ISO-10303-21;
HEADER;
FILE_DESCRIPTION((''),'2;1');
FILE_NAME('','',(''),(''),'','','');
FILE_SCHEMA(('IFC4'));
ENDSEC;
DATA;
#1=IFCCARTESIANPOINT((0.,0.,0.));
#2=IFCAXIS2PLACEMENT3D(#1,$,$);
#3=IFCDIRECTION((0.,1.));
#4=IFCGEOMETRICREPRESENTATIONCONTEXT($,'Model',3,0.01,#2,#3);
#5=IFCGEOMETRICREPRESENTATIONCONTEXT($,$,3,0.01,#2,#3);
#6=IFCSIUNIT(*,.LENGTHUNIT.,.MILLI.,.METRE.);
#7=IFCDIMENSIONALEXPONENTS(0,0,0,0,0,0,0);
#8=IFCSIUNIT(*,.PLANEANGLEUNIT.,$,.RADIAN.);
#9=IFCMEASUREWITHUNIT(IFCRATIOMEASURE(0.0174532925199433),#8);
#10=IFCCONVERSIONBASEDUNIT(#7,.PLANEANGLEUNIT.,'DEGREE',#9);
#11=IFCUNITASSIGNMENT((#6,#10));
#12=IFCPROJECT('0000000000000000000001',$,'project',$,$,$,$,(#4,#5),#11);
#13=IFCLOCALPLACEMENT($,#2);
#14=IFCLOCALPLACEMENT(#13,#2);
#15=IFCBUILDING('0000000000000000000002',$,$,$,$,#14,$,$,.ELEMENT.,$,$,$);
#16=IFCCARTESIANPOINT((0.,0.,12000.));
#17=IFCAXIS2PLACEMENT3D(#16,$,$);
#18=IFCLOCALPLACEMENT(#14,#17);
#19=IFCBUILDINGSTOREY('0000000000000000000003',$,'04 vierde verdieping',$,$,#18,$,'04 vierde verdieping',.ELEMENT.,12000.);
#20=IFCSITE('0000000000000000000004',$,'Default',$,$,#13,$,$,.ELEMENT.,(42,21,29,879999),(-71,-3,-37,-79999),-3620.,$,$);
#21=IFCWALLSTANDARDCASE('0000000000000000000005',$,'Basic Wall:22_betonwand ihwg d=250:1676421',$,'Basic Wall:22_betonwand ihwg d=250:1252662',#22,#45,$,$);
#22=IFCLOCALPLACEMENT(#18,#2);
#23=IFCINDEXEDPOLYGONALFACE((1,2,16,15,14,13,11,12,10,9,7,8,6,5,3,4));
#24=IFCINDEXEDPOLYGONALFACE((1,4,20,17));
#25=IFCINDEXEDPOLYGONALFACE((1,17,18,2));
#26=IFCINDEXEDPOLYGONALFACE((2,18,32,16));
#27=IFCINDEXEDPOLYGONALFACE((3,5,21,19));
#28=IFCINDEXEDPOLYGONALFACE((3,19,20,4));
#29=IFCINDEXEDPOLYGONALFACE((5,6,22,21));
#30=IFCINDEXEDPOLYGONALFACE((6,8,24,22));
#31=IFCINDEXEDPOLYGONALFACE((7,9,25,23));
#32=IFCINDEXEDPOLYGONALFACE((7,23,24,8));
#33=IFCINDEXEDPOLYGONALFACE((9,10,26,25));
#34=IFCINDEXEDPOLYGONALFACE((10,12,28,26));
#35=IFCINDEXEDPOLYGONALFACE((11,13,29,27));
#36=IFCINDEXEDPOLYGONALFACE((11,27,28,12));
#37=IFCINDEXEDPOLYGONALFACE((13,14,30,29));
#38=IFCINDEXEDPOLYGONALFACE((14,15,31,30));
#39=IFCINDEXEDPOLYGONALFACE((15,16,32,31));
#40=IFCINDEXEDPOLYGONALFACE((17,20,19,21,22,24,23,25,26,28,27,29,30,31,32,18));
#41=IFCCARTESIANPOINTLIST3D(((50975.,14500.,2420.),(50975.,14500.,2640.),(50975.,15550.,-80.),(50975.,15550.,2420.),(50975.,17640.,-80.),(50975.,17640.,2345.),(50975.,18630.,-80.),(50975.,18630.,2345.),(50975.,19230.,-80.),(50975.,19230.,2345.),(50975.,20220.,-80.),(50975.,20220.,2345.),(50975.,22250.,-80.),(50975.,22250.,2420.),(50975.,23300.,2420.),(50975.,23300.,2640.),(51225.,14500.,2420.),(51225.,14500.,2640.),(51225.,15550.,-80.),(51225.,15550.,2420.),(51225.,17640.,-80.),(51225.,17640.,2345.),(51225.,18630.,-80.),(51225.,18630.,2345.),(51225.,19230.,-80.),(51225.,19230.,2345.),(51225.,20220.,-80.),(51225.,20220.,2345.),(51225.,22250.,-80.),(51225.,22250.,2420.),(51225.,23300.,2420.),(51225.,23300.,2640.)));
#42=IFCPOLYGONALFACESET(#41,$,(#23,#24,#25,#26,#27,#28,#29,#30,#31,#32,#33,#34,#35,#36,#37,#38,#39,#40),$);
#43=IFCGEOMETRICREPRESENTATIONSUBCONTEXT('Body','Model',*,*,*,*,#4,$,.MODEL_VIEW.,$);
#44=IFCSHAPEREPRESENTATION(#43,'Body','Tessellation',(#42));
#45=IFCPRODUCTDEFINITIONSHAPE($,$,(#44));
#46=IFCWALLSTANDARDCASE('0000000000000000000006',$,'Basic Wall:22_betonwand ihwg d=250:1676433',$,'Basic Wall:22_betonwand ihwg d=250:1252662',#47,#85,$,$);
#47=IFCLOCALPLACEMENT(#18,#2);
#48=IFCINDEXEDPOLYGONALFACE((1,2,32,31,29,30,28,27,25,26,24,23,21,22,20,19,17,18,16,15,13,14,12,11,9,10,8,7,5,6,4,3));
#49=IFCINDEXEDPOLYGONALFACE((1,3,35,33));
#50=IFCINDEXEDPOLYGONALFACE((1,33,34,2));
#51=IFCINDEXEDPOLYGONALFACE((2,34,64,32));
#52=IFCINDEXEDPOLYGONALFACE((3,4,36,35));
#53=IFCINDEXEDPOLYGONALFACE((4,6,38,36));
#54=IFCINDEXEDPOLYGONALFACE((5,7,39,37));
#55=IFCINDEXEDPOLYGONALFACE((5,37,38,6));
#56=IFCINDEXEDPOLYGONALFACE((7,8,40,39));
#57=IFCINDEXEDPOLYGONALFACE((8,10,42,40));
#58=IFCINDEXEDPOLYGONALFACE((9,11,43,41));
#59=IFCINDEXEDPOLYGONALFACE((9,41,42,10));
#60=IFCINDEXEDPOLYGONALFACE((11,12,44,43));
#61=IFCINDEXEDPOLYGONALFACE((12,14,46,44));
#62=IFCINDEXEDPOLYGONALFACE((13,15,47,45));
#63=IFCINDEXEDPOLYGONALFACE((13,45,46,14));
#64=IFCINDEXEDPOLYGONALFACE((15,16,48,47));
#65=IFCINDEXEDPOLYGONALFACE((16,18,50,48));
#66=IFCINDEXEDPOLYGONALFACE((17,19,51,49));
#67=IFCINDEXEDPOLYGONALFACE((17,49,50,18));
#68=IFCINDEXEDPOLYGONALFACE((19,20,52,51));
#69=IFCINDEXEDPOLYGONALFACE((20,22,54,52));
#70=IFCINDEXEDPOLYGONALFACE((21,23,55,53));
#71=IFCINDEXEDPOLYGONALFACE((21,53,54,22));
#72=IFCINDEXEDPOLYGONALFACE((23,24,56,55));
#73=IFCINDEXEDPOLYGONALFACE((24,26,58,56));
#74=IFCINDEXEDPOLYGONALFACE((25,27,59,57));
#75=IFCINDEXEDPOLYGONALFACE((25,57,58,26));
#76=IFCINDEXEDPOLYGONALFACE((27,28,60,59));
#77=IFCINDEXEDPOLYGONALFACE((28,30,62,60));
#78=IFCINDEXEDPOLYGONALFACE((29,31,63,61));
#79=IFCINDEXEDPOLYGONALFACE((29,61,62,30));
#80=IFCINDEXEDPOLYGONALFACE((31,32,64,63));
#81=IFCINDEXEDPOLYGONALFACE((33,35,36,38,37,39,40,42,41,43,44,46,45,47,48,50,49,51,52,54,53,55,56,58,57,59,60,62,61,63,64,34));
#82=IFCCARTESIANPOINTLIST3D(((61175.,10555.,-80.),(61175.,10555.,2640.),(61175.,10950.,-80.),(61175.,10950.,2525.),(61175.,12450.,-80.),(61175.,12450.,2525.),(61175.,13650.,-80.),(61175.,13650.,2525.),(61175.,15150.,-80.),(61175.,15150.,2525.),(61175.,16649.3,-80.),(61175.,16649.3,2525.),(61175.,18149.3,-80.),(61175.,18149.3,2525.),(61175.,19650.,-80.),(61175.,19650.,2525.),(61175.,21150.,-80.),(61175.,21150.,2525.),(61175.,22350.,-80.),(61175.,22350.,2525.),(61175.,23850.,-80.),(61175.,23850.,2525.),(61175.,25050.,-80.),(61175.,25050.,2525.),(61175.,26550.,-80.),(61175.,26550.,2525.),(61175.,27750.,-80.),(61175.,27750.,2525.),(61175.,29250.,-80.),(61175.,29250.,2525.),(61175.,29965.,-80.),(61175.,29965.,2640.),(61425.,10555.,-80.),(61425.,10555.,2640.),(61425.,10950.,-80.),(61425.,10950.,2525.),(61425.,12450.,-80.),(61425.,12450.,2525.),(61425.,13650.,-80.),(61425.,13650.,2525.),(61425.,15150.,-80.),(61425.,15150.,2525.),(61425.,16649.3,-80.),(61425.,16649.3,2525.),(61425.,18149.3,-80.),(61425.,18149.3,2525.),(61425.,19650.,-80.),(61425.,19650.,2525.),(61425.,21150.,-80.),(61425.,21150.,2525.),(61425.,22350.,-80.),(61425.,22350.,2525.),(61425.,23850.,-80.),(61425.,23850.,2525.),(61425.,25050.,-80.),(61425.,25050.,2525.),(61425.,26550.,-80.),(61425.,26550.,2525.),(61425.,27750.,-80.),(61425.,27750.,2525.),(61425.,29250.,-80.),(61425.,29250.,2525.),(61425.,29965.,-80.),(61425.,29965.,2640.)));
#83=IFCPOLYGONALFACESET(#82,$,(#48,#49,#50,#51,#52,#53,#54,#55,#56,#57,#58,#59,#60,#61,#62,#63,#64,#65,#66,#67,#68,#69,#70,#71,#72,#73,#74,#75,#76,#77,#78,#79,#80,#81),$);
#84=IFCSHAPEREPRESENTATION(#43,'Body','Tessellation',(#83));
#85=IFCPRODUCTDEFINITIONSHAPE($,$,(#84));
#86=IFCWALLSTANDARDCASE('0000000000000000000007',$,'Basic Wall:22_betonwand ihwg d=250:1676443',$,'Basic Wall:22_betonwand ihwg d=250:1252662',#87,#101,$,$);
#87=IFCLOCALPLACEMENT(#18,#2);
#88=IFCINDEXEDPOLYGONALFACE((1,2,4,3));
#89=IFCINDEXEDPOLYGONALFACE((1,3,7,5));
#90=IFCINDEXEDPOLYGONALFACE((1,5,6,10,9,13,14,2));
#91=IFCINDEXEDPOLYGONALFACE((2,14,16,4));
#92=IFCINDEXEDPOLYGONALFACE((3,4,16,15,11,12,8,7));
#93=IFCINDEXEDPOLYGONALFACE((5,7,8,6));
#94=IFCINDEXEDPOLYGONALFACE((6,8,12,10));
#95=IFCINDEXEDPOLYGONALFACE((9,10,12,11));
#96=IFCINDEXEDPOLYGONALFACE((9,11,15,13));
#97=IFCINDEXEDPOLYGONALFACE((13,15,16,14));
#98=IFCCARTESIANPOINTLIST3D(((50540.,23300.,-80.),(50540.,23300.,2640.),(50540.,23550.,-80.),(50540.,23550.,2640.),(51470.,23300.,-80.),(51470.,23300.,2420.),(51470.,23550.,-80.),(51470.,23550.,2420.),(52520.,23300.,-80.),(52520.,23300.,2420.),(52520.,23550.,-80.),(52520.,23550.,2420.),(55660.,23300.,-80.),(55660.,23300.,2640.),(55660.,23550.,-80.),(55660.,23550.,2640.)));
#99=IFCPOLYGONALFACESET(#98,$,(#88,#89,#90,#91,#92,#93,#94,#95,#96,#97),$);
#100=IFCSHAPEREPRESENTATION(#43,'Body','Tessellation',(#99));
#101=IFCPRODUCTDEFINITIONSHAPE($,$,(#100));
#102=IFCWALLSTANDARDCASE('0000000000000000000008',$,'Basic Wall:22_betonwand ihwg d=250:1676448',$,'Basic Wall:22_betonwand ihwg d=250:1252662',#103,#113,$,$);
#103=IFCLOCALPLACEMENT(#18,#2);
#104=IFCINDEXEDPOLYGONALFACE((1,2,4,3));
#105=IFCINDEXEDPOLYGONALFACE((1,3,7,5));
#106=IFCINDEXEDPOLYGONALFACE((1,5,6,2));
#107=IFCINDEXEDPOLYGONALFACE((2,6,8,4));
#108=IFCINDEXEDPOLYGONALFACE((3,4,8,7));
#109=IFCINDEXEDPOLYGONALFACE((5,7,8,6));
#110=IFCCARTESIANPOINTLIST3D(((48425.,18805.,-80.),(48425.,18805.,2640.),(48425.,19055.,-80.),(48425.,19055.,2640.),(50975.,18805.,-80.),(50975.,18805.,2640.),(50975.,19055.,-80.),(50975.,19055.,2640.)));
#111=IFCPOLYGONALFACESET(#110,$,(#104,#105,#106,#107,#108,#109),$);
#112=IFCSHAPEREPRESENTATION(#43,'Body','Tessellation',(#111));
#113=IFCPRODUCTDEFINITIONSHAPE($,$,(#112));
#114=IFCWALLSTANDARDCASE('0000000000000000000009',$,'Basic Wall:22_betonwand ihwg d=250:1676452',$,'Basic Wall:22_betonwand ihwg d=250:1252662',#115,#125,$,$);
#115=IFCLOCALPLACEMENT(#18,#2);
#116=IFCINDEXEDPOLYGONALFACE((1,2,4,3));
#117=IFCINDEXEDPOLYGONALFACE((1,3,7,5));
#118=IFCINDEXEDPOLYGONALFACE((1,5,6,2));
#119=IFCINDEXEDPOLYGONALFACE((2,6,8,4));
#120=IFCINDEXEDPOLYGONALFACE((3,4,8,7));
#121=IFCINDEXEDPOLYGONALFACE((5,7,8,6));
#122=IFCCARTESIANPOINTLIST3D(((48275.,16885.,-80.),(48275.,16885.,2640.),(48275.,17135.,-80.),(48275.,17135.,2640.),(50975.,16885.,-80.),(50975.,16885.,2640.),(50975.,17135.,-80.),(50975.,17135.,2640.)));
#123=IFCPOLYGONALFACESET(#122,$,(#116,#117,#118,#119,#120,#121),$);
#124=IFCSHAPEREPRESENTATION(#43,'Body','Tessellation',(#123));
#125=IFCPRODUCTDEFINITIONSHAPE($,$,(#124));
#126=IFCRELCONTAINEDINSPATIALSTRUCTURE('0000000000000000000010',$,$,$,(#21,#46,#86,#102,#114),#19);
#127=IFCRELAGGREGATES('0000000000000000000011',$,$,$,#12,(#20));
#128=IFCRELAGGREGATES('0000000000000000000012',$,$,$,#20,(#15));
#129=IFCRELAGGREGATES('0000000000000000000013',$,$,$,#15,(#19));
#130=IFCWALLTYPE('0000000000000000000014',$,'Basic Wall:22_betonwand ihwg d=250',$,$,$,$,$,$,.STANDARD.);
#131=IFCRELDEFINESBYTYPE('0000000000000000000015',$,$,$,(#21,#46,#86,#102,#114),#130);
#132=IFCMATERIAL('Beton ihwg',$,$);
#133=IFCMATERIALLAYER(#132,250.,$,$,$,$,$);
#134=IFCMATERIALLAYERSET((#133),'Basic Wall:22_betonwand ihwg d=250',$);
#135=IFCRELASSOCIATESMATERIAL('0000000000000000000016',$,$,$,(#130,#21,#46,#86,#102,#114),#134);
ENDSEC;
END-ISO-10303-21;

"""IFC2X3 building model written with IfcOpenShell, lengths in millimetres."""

from ifc_helpers import new_model, entity, si_unit, converted_unit, direction, frame, frame_2d, origin, origin_2d_with_axis, place, context, subcontext, project, spatial, rectangle, extrude, material, layer, layer_set, layer_usage, type_object, element, save


model = new_model("IFC2X3")

# Units and contexts
model_context = context("Model", 3, precision=0.01, world=origin(), true_north=direction((0.0, 1.0)))
context_of_model = context(None, 3, precision=0.01, world=origin(), true_north=direction((0.0, 1.0)))
body_context = subcontext(model_context, "Body", "Model", "MODEL_VIEW")
ifc_project = project(units=[si_unit("LENGTHUNIT", "METRE", prefix="MILLI"), converted_unit("PLANEANGLEUNIT", "DEGREE", entity("IfcRatioMeasure", 0.0174532925199433), si_unit("PLANEANGLEUNIT", "RADIAN"), dimensions=[0, 0, 0, 0, 0, 0, 0])], contexts=[model_context, context_of_model])

# Site, building, storey
site_placement = place(None, origin())
site = spatial("IfcSite", under=ifc_project, at=site_placement, Name="Default", CompositionType="ELEMENT", RefLatitude=(42, 21, 29, 879999), RefLongitude=(-71, -3, -37, -79999), RefElevation=-3620.0)
building_placement = place(site_placement, origin())
building = spatial("IfcBuilding", under=site, at=building_placement, CompositionType="ELEMENT")
storey_placement = place(building_placement, frame((0.0, 0.0, 12000.0)))
storey = spatial("IfcBuildingStorey", under=building, at=storey_placement, Name="04 vierde verdieping", LongName="04 vierde verdieping", CompositionType="ELEMENT", Elevation=12000.0)

# Walls, openings
ifc_material_1 = material(Name="Beton ihwg")
ifc_layer_1 = layer(ifc_material_1, 250.0)
ifc_layer_set_1 = layer_set([ifc_layer_1], Name="Basic Wall:22_betonwand ihwg d=250")
ifc_layer_usage_1 = layer_usage(ifc_layer_set_1, "AXIS2", "NEGATIVE", 125.0)
wall_type_1 = type_object("IfcWallType", Name="Basic Wall:22_betonwand ihwg d=250", PredefinedType="STANDARD", material=ifc_layer_set_1)
wall_1_placement = place(storey_placement, frame((51100.0, 23300.0, -80.0), z_axis=(0.0, 0.0, 1.0), x_axis=(0.0, -1.0, 0.0)))
wall_1 = element("IfcWallStandardCase", 1, at=wall_1_placement, inside=storey, type_object=wall_type_1, material=ifc_layer_usage_1, Name="Basic Wall:22_betonwand ihwg d=250:1676421", ObjectType="Basic Wall:22_betonwand ihwg d=250:1252662", context=body_context, shape_type="SweptSolid", body=[
    extrude(rectangle(XDim=8800.0, YDim=250.0, at=frame_2d((4400.0, 0.0), x_axis=(-1.0, 0.0))), origin(), (0.0, 0.0, 1.0), 2720.0),
])
opening_1_placement = place(wall_1_placement, frame((23300.0, -51100.0, 80.0), z_axis=(0.0, 0.0, 1.0), x_axis=(0.0, 1.0, 0.0)))
element("IfcOpeningElement", 2, at=opening_1_placement, cuts=wall_1, ObjectType="Opening", context=body_context, shape_type="SweptSolid", body=[
    extrude(rectangle(XDim=2500.0, YDim=1050.0, at=frame_2d((0.0, 0.0), x_axis=(0.0, 1.0))), frame((50700.0, 15025.0, 1170.0), z_axis=(1.0, 0.0, 0.0), x_axis=(0.0, -1.0, 0.0)), (0.0, 0.0, 1.0), 800.0),
])
opening_2_placement = place(wall_1_placement, frame((23300.0, -51100.0, 80.0), z_axis=(0.0, 0.0, 1.0), x_axis=(0.0, 1.0, 0.0)))
element("IfcOpeningElement", 3, at=opening_2_placement, cuts=wall_1, ObjectType="Opening", context=body_context, shape_type="SweptSolid", body=[
    extrude(rectangle(XDim=2425.0, YDim=990.0, at=frame_2d((0.0, 0.0), x_axis=(1.0, 0.0))), frame((50700.0, 19725.0, 1132.5), z_axis=(1.0, 0.0, 0.0), x_axis=(0.0, 0.0, -1.0)), (0.0, 0.0, 1.0), 800.0),
])
opening_3_placement = place(wall_1_placement, frame((23300.0, -51100.0, 80.0), z_axis=(0.0, 0.0, 1.0), x_axis=(0.0, 1.0, 0.0)))
element("IfcOpeningElement", 4, at=opening_3_placement, cuts=wall_1, ObjectType="Opening", context=body_context, shape_type="SweptSolid", body=[
    extrude(rectangle(XDim=2425.0, YDim=990.0, at=origin_2d_with_axis()), frame((50700.0, 18135.0, 1132.5), z_axis=(1.0, 0.0, 0.0), x_axis=(0.0, 0.0, -1.0)), (0.0, 0.0, 1.0), 800.0),
])
opening_4_placement = place(wall_1_placement, frame((23300.0, -51100.0, 80.0), z_axis=(0.0, 0.0, 1.0), x_axis=(0.0, 1.0, 0.0)))
element("IfcOpeningElement", 5, at=opening_4_placement, cuts=wall_1, ObjectType="Opening", context=body_context, shape_type="SweptSolid", body=[
    extrude(rectangle(XDim=2500.0, YDim=1050.0, at=frame_2d((0.0, 0.0), x_axis=(1.0, 0.0))), frame((50700.0, 22775.0, 1170.0), z_axis=(1.0, 0.0, 0.0), x_axis=(0.0, 0.0, -1.0)), (0.0, 0.0, 1.0), 800.0),
])
ifc_layer_usage_2 = layer_usage(ifc_layer_set_1, "AXIS2", "POSITIVE", -125.0)
wall_2_placement = place(storey_placement, frame((61300.0, 29965.0, -80.0), z_axis=(0.0, 0.0, 1.0), x_axis=(0.0, -1.0, 0.0)))
wall_2 = element("IfcWallStandardCase", 6, at=wall_2_placement, inside=storey, type_object=wall_type_1, material=ifc_layer_usage_2, Name="Basic Wall:22_betonwand ihwg d=250:1676433", ObjectType="Basic Wall:22_betonwand ihwg d=250:1252662", context=body_context, shape_type="SweptSolid", body=[
    extrude(rectangle(XDim=19410.0, YDim=250.0, at=frame_2d((9705.0, 0.0), x_axis=(-1.0, 0.0))), origin(), (0.0, 0.0, 1.0), 2720.0),
])
opening_5_placement = place(wall_2_placement, frame((29965.0, -61300.0, 80.0), z_axis=(0.0, 0.0, 1.0), x_axis=(0.0, 1.0, 0.0)))
element("IfcOpeningElement", 7, at=opening_5_placement, cuts=wall_2, ObjectType="Opening", context=body_context, shape_type="SweptSolid", body=[
    extrude(rectangle(XDim=2605.0, YDim=1500.0, at=frame_2d((0.0, 0.0), x_axis=(1.0, 0.0))), frame((59901.0, 28500.0, 1222.5), z_axis=(1.0, 0.0, 0.0), x_axis=(0.0, 0.0, -1.0)), (0.0, 0.0, 1.0), 3048.0),
])
opening_6_placement = place(wall_2_placement, frame((29965.0, -61300.0, 80.0), z_axis=(0.0, 0.0, 1.0), x_axis=(0.0, 1.0, 0.0)))
element("IfcOpeningElement", 8, at=opening_6_placement, cuts=wall_2, ObjectType="Opening", context=body_context, shape_type="SweptSolid", body=[
    extrude(rectangle(XDim=2605.0, YDim=1500.0, at=frame_2d((0.0, 0.0), x_axis=(1.0, 0.0))), frame((59901.0, 25800.0, 1222.5), z_axis=(1.0, 0.0, 0.0), x_axis=(0.0, 0.0, -1.0)), (0.0, 0.0, 1.0), 3048.0),
])
opening_7_placement = place(wall_2_placement, frame((29965.0, -61300.0, 80.0), z_axis=(0.0, 0.0, 1.0), x_axis=(0.0, 1.0, 0.0)))
element("IfcOpeningElement", 9, at=opening_7_placement, cuts=wall_2, ObjectType="Opening", context=body_context, shape_type="SweptSolid", body=[
    extrude(rectangle(XDim=2605.0, YDim=1500.0, at=frame_2d((0.0, 0.0), x_axis=(1.0, 0.0))), frame((59901.0, 23100.0, 1222.5), z_axis=(1.0, 0.0, 0.0), x_axis=(0.0, 0.0, -1.0)), (0.0, 0.0, 1.0), 3048.0),
])
opening_8_placement = place(wall_2_placement, frame((29965.0, -61300.0, 80.0), z_axis=(0.0, 0.0, 1.0), x_axis=(0.0, 1.0, 0.0)))
element("IfcOpeningElement", 10, at=opening_8_placement, cuts=wall_2, ObjectType="Opening", context=body_context, shape_type="SweptSolid", body=[
    extrude(rectangle(XDim=2605.0, YDim=1500.0, at=frame_2d((0.0, 0.0), x_axis=(1.0, 0.0))), frame((59901.0, 17399.3, 1222.5), z_axis=(1.0, 0.0, 0.0), x_axis=(0.0, 0.0, -1.0)), (0.0, 0.0, 1.0), 3048.0),
])
opening_9_placement = place(wall_2_placement, frame((29965.0, -61300.0, 80.0), z_axis=(0.0, 0.0, 1.0), x_axis=(0.0, 1.0, 0.0)))
element("IfcOpeningElement", 11, at=opening_9_placement, cuts=wall_2, ObjectType="Opening", context=body_context, shape_type="SweptSolid", body=[
    extrude(rectangle(XDim=2605.0, YDim=1500.0, at=frame_2d((0.0, 0.0), x_axis=(1.0, 0.0))), frame((59901.0, 14400.0, 1222.5), z_axis=(1.0, 0.0, 0.0), x_axis=(0.0, 0.0, -1.0)), (0.0, 0.0, 1.0), 3048.0),
])
opening_10_placement = place(wall_2_placement, frame((29965.0, -61300.0, 80.0), z_axis=(0.0, 0.0, 1.0), x_axis=(0.0, 1.0, 0.0)))
element("IfcOpeningElement", 12, at=opening_10_placement, cuts=wall_2, ObjectType="Opening", context=body_context, shape_type="SweptSolid", body=[
    extrude(rectangle(XDim=2605.0, YDim=1500.0, at=frame_2d((0.0, 0.0), x_axis=(1.0, 0.0))), frame((59901.0, 20400.0, 1222.5), z_axis=(1.0, 0.0, 0.0), x_axis=(0.0, 0.0, -1.0)), (0.0, 0.0, 1.0), 3048.0),
])
opening_11_placement = place(wall_2_placement, frame((29965.0, -61300.0, 80.0), z_axis=(0.0, 0.0, 1.0), x_axis=(0.0, 1.0, 0.0)))
element("IfcOpeningElement", 13, at=opening_11_placement, cuts=wall_2, ObjectType="Opening", context=body_context, shape_type="SweptSolid", body=[
    extrude(rectangle(XDim=2605.0, YDim=1500.0, at=frame_2d((0.0, 0.0), x_axis=(1.0, 0.0))), frame((59901.0, 11700.0, 1222.5), z_axis=(1.0, 0.0, 0.0), x_axis=(0.0, 0.0, -1.0)), (0.0, 0.0, 1.0), 3048.0),
])
ifc_layer_usage_3 = layer_usage(ifc_layer_set_1, "AXIS2", "POSITIVE", -125.0)
wall_3_placement = place(storey_placement, frame((55660.0, 23425.0, -80.0), z_axis=(0.0, 0.0, 1.0), x_axis=(-1.0, 0.0, 0.0)))
wall_3 = element("IfcWallStandardCase", 14, at=wall_3_placement, inside=storey, type_object=wall_type_1, material=ifc_layer_usage_3, Name="Basic Wall:22_betonwand ihwg d=250:1676443", ObjectType="Basic Wall:22_betonwand ihwg d=250:1252662", context=body_context, shape_type="SweptSolid", body=[
    extrude(rectangle(XDim=5120.0, YDim=250.0, at=frame_2d((2560.0, 0.0), x_axis=(-1.0, 0.0))), origin(), (0.0, 0.0, 1.0), 2720.0),
])
opening_12_placement = place(wall_3_placement, origin())
element("IfcOpeningElement", 15, at=opening_12_placement, cuts=wall_3, ObjectType="Opening", context=body_context, shape_type="SweptSolid", body=[
    extrude(rectangle(XDim=2500.0, YDim=800.0, at=frame_2d((0.0, 0.0), x_axis=(0.0, 1.0))), frame((2735.0, 125.0, 1250.0), z_axis=(0.0, 1.0, 0.0), x_axis=(1.0, 0.0, 0.0)), (0.0, 0.0, 1.0), 1034.0),
])
opening_13_placement = place(wall_3_placement, origin())
element("IfcOpeningElement", 16, at=opening_13_placement, cuts=wall_3, ObjectType="Opening", context=body_context, shape_type="SweptSolid", body=[
    extrude(rectangle(XDim=2500.0, YDim=800.0, at=frame_2d((0.0, 0.0), x_axis=(0.0, 1.0))), frame((4560.0, 125.0, 1250.0), z_axis=(0.0, 1.0, 0.0), x_axis=(1.0, 0.0, 0.0)), (0.0, 0.0, 1.0), 1050.0),
])
opening_14_placement = place(wall_3_placement, frame((55660.0, 23425.0, 80.0), z_axis=(0.0, 0.0, 1.0), x_axis=(-1.0, 0.0, 0.0)))
element("IfcOpeningElement", 17, at=opening_14_placement, cuts=wall_3, ObjectType="Opening", context=body_context, shape_type="SweptSolid", body=[
    extrude(rectangle(XDim=2500.0, YDim=1050.0, at=frame_2d((0.0, 0.0), x_axis=(0.0, 1.0))), frame((51995.0, 23825.0, 1170.0), z_axis=(0.0, -1.0, 0.0), x_axis=(-1.0, 0.0, 0.0)), (0.0, 0.0, 1.0), 800.0),
])

# Walls
ifc_layer_usage_4 = layer_usage(ifc_layer_set_1, "AXIS2", "POSITIVE", -125.0)
wall_4_placement = place(storey_placement, frame((50975.0, 18930.0, -80.0), z_axis=(0.0, 0.0, 1.0), x_axis=(-1.0, 0.0, 0.0)))
element("IfcWallStandardCase", 18, at=wall_4_placement, inside=storey, type_object=wall_type_1, material=ifc_layer_usage_4, Name="Basic Wall:22_betonwand ihwg d=250:1676448", ObjectType="Basic Wall:22_betonwand ihwg d=250:1252662", context=body_context, shape_type="SweptSolid", body=[
    extrude(rectangle(XDim=2550.0, YDim=250.0, at=frame_2d((1275.0, 0.0), x_axis=(-1.0, 0.0))), origin(), (0.0, 0.0, 1.0), 2720.0),
])
ifc_layer_usage_5 = layer_usage(ifc_layer_set_1, "AXIS2", "POSITIVE", -125.0)
wall_5_placement = place(storey_placement, frame((50975.0, 17010.0, -80.0), z_axis=(0.0, 0.0, 1.0), x_axis=(-1.0, 0.0, 0.0)))
element("IfcWallStandardCase", 19, at=wall_5_placement, inside=storey, type_object=wall_type_1, material=ifc_layer_usage_5, Name="Basic Wall:22_betonwand ihwg d=250:1676452", ObjectType="Basic Wall:22_betonwand ihwg d=250:1252662", context=body_context, shape_type="SweptSolid", body=[
    extrude(rectangle(XDim=2700.0, YDim=250.0, at=frame_2d((1350.0, 0.0), x_axis=(-1.0, 0.0))), origin(), (0.0, 0.0, 1.0), 2720.0),
])

save(model, "model.ifc")
